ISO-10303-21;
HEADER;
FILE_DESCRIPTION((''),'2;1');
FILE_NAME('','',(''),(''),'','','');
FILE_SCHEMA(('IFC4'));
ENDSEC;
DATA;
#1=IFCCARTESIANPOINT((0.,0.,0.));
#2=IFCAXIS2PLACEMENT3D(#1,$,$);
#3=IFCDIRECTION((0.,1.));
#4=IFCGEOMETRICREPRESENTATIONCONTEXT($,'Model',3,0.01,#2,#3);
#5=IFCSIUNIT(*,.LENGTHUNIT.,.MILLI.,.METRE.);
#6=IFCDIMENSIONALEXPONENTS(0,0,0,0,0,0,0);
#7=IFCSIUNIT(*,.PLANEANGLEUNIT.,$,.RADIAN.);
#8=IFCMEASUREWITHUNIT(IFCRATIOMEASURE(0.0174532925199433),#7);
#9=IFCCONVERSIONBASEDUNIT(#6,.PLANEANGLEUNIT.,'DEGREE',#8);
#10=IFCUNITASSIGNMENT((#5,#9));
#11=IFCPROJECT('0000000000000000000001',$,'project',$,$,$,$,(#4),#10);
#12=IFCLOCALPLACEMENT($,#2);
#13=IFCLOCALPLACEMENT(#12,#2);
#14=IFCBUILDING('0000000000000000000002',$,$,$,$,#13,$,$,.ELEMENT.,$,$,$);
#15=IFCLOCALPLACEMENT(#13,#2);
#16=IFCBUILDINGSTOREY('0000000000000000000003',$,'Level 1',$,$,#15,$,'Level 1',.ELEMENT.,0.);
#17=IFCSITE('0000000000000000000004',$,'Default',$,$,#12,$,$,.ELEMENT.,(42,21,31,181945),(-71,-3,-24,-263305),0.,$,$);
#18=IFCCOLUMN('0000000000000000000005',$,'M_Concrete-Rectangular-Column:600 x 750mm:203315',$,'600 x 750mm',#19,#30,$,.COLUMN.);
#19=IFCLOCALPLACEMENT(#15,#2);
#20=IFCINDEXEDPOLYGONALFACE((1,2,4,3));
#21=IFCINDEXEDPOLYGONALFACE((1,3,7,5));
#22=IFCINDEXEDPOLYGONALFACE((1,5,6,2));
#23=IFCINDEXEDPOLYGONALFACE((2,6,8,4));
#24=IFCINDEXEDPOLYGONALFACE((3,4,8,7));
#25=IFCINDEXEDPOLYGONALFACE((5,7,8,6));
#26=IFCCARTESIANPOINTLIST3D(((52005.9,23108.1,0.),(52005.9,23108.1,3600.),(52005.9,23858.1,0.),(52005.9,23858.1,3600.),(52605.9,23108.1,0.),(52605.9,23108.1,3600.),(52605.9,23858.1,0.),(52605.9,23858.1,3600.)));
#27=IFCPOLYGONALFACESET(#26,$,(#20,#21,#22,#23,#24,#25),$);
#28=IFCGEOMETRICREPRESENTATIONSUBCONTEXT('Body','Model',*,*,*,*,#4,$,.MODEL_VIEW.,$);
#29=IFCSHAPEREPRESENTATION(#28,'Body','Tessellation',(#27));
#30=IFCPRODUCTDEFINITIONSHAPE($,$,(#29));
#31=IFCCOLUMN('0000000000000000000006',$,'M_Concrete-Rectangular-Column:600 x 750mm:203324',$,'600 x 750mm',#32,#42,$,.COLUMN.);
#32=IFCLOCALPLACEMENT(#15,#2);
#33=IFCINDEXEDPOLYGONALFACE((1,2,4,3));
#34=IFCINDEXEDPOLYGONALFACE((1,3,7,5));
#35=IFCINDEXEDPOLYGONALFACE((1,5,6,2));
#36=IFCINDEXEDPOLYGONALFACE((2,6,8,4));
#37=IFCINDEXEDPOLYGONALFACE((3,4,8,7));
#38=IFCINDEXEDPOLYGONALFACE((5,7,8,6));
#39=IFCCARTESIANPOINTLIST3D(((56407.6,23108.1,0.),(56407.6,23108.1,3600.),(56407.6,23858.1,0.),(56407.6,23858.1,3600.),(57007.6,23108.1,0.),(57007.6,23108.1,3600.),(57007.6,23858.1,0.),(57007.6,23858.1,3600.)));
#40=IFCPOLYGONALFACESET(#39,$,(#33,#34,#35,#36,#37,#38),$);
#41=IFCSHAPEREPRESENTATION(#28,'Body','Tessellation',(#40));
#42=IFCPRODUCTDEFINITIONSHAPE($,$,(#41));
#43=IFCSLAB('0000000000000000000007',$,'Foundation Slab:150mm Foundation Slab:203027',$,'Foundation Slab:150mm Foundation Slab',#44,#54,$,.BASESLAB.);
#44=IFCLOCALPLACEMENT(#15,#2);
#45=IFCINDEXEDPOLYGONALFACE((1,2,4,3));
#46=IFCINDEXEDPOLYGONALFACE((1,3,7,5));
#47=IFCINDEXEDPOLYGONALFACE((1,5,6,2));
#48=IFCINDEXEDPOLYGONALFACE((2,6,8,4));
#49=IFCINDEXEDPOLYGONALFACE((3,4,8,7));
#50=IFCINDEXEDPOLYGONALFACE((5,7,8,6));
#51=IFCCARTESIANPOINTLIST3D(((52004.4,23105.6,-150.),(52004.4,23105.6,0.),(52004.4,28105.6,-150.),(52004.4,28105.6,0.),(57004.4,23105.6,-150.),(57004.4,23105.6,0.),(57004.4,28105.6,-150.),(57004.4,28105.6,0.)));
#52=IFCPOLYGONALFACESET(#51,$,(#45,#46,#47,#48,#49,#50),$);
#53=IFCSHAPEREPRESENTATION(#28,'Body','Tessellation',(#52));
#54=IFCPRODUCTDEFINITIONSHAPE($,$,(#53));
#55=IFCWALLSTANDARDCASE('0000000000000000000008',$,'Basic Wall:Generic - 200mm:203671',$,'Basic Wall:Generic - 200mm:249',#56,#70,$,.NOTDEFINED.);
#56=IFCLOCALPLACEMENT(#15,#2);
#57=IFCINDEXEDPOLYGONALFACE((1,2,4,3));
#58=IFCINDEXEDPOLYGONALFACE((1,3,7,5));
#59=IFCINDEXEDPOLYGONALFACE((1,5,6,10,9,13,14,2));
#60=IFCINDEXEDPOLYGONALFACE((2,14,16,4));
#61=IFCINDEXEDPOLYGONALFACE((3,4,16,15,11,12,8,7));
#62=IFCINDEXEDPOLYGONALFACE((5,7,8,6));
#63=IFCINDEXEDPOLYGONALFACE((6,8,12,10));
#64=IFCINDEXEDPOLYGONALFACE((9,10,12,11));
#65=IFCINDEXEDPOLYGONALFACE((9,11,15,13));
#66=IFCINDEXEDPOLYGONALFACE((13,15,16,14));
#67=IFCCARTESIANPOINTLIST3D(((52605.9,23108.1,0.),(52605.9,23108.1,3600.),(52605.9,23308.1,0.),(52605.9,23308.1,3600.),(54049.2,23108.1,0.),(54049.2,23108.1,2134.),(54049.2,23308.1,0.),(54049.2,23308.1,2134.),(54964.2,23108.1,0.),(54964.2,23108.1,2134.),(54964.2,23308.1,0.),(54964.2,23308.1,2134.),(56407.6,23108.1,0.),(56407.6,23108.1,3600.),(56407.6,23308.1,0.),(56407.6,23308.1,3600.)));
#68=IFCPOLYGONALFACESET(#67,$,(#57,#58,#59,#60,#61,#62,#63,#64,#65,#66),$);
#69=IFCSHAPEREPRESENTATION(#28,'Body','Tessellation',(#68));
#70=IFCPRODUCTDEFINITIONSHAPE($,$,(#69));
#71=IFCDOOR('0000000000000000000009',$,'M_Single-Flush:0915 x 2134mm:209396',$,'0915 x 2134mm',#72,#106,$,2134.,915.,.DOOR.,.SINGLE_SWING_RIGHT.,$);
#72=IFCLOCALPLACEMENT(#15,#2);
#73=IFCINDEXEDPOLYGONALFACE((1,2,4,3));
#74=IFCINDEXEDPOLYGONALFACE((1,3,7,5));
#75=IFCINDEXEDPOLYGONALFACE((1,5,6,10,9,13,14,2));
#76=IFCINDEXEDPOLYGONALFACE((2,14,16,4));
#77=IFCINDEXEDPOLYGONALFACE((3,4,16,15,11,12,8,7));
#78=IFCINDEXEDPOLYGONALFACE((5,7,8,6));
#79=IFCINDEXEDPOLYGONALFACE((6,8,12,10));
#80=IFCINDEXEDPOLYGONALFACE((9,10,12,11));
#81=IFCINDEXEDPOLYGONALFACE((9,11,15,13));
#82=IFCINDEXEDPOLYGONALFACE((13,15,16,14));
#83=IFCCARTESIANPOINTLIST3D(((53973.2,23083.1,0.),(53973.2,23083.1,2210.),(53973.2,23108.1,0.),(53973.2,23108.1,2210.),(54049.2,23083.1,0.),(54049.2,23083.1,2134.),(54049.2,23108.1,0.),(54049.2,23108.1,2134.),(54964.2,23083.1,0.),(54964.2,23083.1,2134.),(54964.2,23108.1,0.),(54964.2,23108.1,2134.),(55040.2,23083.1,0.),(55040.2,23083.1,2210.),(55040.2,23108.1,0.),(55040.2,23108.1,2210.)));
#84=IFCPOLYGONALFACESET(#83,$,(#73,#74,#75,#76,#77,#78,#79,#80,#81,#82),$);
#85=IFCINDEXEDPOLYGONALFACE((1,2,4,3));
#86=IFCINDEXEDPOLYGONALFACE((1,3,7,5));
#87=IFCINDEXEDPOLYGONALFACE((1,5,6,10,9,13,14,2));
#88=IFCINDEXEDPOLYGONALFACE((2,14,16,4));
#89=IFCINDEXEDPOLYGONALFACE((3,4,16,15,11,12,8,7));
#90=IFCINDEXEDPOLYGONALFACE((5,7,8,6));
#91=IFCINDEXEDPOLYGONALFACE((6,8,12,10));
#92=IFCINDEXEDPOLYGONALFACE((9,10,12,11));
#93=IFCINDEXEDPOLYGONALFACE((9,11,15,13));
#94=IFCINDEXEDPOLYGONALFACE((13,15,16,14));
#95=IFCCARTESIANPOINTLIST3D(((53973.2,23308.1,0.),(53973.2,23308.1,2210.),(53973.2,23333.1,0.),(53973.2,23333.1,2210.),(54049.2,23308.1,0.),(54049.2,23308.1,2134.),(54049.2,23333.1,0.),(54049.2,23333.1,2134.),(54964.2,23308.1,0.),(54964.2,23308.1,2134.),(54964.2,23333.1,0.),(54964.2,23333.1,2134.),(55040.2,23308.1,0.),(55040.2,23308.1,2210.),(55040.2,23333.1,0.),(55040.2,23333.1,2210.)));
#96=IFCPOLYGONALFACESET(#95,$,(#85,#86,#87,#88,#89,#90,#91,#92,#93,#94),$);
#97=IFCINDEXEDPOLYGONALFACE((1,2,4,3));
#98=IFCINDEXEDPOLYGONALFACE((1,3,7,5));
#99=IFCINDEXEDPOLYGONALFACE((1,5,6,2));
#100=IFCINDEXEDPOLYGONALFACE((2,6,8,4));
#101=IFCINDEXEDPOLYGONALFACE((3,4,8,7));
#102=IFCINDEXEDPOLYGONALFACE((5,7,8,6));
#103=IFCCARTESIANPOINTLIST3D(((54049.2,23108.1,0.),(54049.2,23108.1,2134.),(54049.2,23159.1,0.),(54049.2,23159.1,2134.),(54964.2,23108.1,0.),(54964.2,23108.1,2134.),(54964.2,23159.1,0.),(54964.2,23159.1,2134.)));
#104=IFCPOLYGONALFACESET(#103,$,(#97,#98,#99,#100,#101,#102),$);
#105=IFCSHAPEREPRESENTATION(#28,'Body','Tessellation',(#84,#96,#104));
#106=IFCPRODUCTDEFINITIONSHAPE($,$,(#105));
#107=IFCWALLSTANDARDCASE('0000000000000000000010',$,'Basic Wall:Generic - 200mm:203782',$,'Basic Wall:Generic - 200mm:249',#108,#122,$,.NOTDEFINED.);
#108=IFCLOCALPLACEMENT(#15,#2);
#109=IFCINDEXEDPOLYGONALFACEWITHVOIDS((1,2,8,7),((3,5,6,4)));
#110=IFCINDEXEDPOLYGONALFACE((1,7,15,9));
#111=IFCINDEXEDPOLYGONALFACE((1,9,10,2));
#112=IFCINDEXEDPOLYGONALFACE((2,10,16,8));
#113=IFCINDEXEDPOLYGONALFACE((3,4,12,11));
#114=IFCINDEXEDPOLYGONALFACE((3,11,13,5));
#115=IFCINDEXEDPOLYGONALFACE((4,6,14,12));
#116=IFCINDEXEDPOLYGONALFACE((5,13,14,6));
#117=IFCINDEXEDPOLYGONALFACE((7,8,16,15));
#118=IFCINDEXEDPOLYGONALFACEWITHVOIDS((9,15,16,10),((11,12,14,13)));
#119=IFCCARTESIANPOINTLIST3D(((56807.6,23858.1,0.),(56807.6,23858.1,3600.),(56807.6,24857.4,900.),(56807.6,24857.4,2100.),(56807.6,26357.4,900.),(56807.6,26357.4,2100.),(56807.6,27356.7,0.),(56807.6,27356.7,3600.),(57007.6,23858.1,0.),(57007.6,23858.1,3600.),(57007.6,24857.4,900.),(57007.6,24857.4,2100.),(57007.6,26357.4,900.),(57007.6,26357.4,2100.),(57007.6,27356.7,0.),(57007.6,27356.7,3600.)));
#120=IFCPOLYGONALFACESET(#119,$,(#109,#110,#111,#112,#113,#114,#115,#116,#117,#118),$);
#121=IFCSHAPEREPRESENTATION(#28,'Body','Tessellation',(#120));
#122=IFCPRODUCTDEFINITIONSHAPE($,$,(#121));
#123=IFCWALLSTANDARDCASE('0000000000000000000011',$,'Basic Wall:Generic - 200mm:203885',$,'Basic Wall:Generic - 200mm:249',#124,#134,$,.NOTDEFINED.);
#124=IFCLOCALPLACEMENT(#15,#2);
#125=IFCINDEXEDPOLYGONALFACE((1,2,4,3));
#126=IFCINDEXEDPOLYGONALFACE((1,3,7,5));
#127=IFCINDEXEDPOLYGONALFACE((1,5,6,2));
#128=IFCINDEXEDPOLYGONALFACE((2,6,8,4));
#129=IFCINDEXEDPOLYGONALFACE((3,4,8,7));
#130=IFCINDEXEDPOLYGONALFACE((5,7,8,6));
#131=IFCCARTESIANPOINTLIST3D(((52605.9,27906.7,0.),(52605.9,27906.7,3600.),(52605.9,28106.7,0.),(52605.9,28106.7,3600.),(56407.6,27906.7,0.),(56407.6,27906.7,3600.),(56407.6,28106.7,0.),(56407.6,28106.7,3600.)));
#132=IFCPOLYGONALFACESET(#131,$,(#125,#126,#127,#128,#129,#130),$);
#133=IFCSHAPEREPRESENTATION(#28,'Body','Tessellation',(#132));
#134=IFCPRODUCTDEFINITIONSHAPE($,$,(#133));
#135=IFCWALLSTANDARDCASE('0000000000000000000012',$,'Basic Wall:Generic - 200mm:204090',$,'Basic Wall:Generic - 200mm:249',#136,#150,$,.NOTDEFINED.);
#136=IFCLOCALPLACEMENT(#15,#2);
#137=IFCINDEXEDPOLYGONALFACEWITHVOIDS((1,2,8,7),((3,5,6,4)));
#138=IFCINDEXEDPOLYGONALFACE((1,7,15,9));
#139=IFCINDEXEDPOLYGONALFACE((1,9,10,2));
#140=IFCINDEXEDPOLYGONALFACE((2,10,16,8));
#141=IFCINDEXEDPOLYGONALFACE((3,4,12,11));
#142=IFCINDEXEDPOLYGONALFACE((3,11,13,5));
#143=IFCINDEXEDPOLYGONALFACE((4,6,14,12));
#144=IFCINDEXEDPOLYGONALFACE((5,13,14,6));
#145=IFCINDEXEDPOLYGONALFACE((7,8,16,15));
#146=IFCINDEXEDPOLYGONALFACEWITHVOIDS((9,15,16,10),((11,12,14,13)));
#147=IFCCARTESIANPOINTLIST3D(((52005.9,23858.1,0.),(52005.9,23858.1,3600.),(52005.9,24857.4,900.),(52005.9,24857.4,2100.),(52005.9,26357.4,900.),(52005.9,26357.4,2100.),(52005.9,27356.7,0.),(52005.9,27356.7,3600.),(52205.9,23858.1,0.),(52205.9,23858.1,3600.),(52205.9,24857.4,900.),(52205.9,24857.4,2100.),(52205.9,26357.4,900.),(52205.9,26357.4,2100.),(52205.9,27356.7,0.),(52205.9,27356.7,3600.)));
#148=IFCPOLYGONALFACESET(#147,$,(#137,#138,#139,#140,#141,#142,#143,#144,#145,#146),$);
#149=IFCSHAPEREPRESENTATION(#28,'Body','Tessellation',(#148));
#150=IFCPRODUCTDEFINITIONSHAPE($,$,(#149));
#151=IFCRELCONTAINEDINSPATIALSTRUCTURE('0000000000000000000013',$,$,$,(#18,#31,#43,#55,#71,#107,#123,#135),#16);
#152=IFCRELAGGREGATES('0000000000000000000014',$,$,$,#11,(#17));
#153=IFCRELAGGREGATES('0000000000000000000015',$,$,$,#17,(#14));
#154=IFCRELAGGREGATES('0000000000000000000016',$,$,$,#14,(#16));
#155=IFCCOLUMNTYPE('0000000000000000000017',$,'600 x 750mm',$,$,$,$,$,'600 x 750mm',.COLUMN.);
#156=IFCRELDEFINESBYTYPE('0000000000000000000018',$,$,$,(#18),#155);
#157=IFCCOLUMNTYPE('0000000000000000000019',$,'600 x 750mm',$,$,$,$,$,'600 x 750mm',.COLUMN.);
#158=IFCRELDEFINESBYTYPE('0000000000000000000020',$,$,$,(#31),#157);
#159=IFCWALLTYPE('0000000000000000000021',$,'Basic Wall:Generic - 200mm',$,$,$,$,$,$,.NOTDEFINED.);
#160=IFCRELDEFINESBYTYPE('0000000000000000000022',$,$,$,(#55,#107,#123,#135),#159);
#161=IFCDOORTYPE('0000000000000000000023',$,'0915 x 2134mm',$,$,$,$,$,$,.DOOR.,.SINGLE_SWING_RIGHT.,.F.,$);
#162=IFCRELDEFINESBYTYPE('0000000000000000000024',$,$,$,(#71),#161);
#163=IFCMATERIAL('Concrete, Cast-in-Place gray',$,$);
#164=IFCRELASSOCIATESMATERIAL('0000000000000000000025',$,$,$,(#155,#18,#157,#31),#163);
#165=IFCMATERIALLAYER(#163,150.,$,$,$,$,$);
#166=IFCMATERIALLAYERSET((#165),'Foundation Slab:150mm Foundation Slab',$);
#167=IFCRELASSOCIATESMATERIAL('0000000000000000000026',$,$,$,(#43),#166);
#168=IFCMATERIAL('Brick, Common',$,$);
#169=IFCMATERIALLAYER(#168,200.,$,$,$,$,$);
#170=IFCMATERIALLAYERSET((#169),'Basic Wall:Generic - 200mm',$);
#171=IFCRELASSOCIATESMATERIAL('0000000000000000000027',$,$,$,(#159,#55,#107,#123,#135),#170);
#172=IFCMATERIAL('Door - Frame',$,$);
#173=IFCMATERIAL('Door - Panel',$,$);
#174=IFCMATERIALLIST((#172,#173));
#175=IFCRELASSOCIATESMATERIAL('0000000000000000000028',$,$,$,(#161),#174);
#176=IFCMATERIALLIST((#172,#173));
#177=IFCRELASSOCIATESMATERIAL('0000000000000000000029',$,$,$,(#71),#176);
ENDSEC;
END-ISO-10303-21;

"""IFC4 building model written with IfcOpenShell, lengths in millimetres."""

from ifc_helpers import new_model, entity, si_unit, converted_unit, direction, frame, frame_2d, origin, origin_2d_with_axis, place, context, subcontext, project, spatial, polyline, rectangle, outline, extrude, source, transform, mapped, material, material_list, layer, layer_set, layer_usage, type_object, type_shapes, element, fill, save


model = new_model("IFC4")

# Units and contexts
model_context = context("Model", 3, precision=0.01, world=origin(), true_north=direction((0.0, 1.0)))
body_context = subcontext(model_context, "Body", "Model", "MODEL_VIEW")
ifc_project = project(units=[si_unit("LENGTHUNIT", "METRE", prefix="MILLI"), converted_unit("PLANEANGLEUNIT", "DEGREE", entity("IfcRatioMeasure", 0.0174532925199433), si_unit("PLANEANGLEUNIT", "RADIAN"), dimensions=[0, 0, 0, 0, 0, 0, 0])], contexts=[model_context])

# Site, building, storey
site_placement = place(None, origin())
site = spatial("IfcSite", under=ifc_project, at=site_placement, Name="Default", CompositionType="ELEMENT", RefLatitude=(42, 21, 31, 181945), RefLongitude=(-71, -3, -24, -263305), RefElevation=0.0)
building_placement = place(site_placement, origin())
building = spatial("IfcBuilding", under=site, at=building_placement, CompositionType="ELEMENT")
storey_placement = place(building_placement, origin())
storey = spatial("IfcBuildingStorey", under=building, at=storey_placement, Name="Level 1", LongName="Level 1", CompositionType="ELEMENT", Elevation=0.0)

# Columns
ifc_material_1 = material(Name="Concrete, Cast-in-Place gray")
column_type_1 = type_object("IfcColumnType", Name="600 x 750mm", ElementType="600 x 750mm", PredefinedType="COLUMN", material=ifc_material_1)
shared_shape_1 = source(origin(), body_context, "Body", "SweptSolid", [
    extrude(rectangle(XDim=750.0, YDim=600.0, at=origin_2d_with_axis()), frame((52305.9, 23483.1, 0.0), z_axis=(0.0, 0.0, 1.0), x_axis=(0.0, -1.0, 0.0)), (0.0, 0.0, 1.0), 3600.0),
])
type_shapes(column_type_1, [shared_shape_1])
column_1_placement = place(storey_placement, origin())
element("IfcColumn", 1, at=column_1_placement, inside=storey, type_object=column_type_1, material=ifc_material_1, Name="M_Concrete-Rectangular-Column:600 x 750mm:203315", ObjectType="600 x 750mm", PredefinedType="COLUMN", context=body_context, shape_type="MappedRepresentation", body=[
    mapped(shared_shape_1, transform((0.0, 0.0, 0.0), scale=1.0)),
])
column_type_2 = type_object("IfcColumnType", Name="600 x 750mm", ElementType="600 x 750mm", PredefinedType="COLUMN", material=ifc_material_1)
shared_shape_2 = source(origin(), body_context, "Body", "SweptSolid", [
    extrude(rectangle(XDim=750.0, YDim=600.0, at=origin_2d_with_axis()), frame((56707.6, 23483.1, 0.0), z_axis=(0.0, 0.0, 1.0), x_axis=(0.0, -1.0, 0.0)), (0.0, 0.0, 1.0), 3600.0),
])
type_shapes(column_type_2, [shared_shape_2])
column_2_placement = place(storey_placement, origin())
element("IfcColumn", 2, at=column_2_placement, inside=storey, type_object=column_type_2, material=ifc_material_1, Name="M_Concrete-Rectangular-Column:600 x 750mm:203324", ObjectType="600 x 750mm", PredefinedType="COLUMN", context=body_context, shape_type="MappedRepresentation", body=[
    mapped(shared_shape_2, transform((0.0, 0.0, 0.0), scale=1.0)),
])

# Slab
ifc_layer_1 = layer(ifc_material_1, 150.0)
ifc_layer_set_1 = layer_set([ifc_layer_1], Name="Foundation Slab:150mm Foundation Slab")
ifc_layer_usage_1 = layer_usage(ifc_layer_set_1, "AXIS3", "POSITIVE", 0.0)
slab_placement = place(storey_placement, origin())
element("IfcSlab", 3, at=slab_placement, inside=storey, material=ifc_layer_usage_1, Name="Foundation Slab:150mm Foundation Slab:203027", ObjectType="Foundation Slab:150mm Foundation Slab", PredefinedType="BASESLAB", context=body_context, shape_type="SweptSolid", body=[
    extrude(rectangle(XDim=5000.0, YDim=5000.0, at=frame_2d((0.0, 0.0), x_axis=(1.0, 0.0))), frame((54504.4, 25605.6, 0.0), z_axis=(0.0, 0.0, -1.0), x_axis=(0.0, 1.0, 0.0)), (0.0, 0.0, 1.0), 150.0),
])

# Wall, opening, door
ifc_material_2 = material(Name="Brick, Common")
ifc_layer_2 = layer(ifc_material_2, 200.0)
ifc_layer_set_2 = layer_set([ifc_layer_2], Name="Basic Wall:Generic - 200mm")
ifc_layer_usage_2 = layer_usage(ifc_layer_set_2, "AXIS2", "POSITIVE", -100.0)
wall_type = type_object("IfcWallType", Name="Basic Wall:Generic - 200mm", PredefinedType="NOTDEFINED", material=ifc_layer_set_2)
wall_1_placement = place(storey_placement, frame((52605.9, 23208.1, 0.0)))
wall_1 = element("IfcWallStandardCase", 4, at=wall_1_placement, inside=storey, type_object=wall_type, material=ifc_layer_usage_2, Name="Basic Wall:Generic - 200mm:203671", ObjectType="Basic Wall:Generic - 200mm:249", PredefinedType="NOTDEFINED", context=body_context, shape_type="SweptSolid", body=[
    extrude(rectangle(XDim=3801.7, YDim=200.0, at=frame_2d((1900.8, 0.0), x_axis=(-1.0, 0.0))), origin(), (0.0, 0.0, 1.0), 3600.0),
])
opening_1_placement = place(wall_1_placement, frame((2358.3, 100.0, 0.0)))
opening_1 = element("IfcOpeningElement", 5, at=opening_1_placement, cuts=wall_1, ObjectType="Opening", PredefinedType="OPENING", context=body_context, shape_type="SweptSolid", body=[
    extrude(rectangle(XDim=915.0, YDim=2134.0, at=frame_2d((1067.0, 457.5), x_axis=(0.0, 1.0))), frame((0.0, 0.0, 0.0), z_axis=(0.0, -1.0, 0.0), x_axis=(0.0, 0.0, 1.0)), (0.0, 0.0, 1.0), 200.0),
])
ifc_material_3 = material(Name="Door - Frame")
ifc_material_4 = material(Name="Door - Panel")
ifc_material_list_1 = material_list([ifc_material_3, ifc_material_4])
ifc_material_list_2 = material_list([ifc_material_3, ifc_material_4])
door_type = type_object("IfcDoorType", Name="0915 x 2134mm", OperationType="SINGLE_SWING_RIGHT", ParameterTakesPrecedence=False, PredefinedType="DOOR", material=ifc_material_list_2)
shared_shape_3 = source(origin(), body_context, "Body", "SweptSolid", [
    extrude(outline(polyline([(-533.5, -1124.0), (533.5, -1124.0), (533.5, 1086.0), (457.5, 1086.0), (457.5, -1048.0), (-457.5, -1048.0), (-457.5, 1086.0), (-533.5, 1086.0), (-533.5, -1124.0)])), frame((457.5, 200.0, 1086.0), z_axis=(0.0, 1.0, 0.0), x_axis=(1.0, 0.0, 0.0)), (0.0, 0.0, 1.0), 25.0),
    extrude(outline(polyline([(-1124.0, -533.5), (1086.0, -533.5), (1086.0, -457.5), (-1048.0, -457.5), (-1048.0, 457.5), (1086.0, 457.5), (1086.0, 533.5), (-1124.0, 533.5), (-1124.0, -533.5)])), frame((457.5, -25.0, 1086.0), z_axis=(0.0, 1.0, 0.0), x_axis=(0.0, 0.0, -1.0)), (0.0, 0.0, 1.0), 25.0),
    extrude(rectangle(XDim=51.0, YDim=915.0, at=frame_2d((0.0, 0.0), x_axis=(1.0, 0.0))), frame((457.5, 174.5, 0.0), z_axis=(0.0, 0.0, 1.0), x_axis=(0.0, 1.0, 0.0)), (0.0, 0.0, 1.0), 2134.0),
])
type_shapes(door_type, [shared_shape_3])
door_placement = place(opening_1_placement, frame((0.0, 0.0, 0.0), z_axis=(0.0, 0.0, 1.0), x_axis=(-1.0, 0.0, 0.0)))
door = element("IfcDoor", 6, at=door_placement, inside=storey, type_object=door_type, material=ifc_material_list_1, Name="M_Single-Flush:0915 x 2134mm:209396", ObjectType="0915 x 2134mm", OperationType="SINGLE_SWING_RIGHT", OverallHeight=2134.0, OverallWidth=915.0, PredefinedType="DOOR", context=body_context, shape_type="MappedRepresentation", body=[
    mapped(shared_shape_3, transform((0.0, 0.0, 0.0), scale=1.0)),
])
fill(opening_1, door)

# Wall, opening
ifc_layer_usage_3 = layer_usage(ifc_layer_set_2, "AXIS2", "POSITIVE", -100.0)
wall_2_placement = place(storey_placement, frame((56907.6, 23858.1, 0.0), z_axis=(0.0, 0.0, 1.0), x_axis=(0.0, 1.0, 0.0)))
wall_2 = element("IfcWallStandardCase", 7, at=wall_2_placement, inside=storey, type_object=wall_type, material=ifc_layer_usage_3, Name="Basic Wall:Generic - 200mm:203782", ObjectType="Basic Wall:Generic - 200mm:249", PredefinedType="NOTDEFINED", context=body_context, shape_type="SweptSolid", body=[
    extrude(rectangle(XDim=3498.6, YDim=200.0, at=frame_2d((1749.3, 0.0), x_axis=(-1.0, 0.0))), origin(), (0.0, 0.0, 1.0), 3600.0),
])
opening_2_placement = place(wall_2_placement, frame((999.3, -100.0, 900.0)))
element("IfcOpeningElement", 8, at=opening_2_placement, cuts=wall_2, ObjectType="Opening", PredefinedType="OPENING", context=body_context, shape_type="SweptSolid", body=[
    extrude(rectangle(XDim=1200.0, YDim=1500.0, at=frame_2d((600.0, 750.0), x_axis=(-1.0, 0.0))), frame((0.0, 0.0, 0.0), z_axis=(0.0, 1.0, 0.0), x_axis=(0.0, 0.0, 1.0)), (0.0, 0.0, 1.0), 200.0),
])

# Wall
ifc_layer_usage_4 = layer_usage(ifc_layer_set_2, "AXIS2", "POSITIVE", -100.0)
wall_3_placement = place(storey_placement, frame((56407.6, 28006.7, 0.0), z_axis=(0.0, 0.0, 1.0), x_axis=(-1.0, 0.0, 0.0)))
element("IfcWallStandardCase", 9, at=wall_3_placement, inside=storey, type_object=wall_type, material=ifc_layer_usage_4, Name="Basic Wall:Generic - 200mm:203885", ObjectType="Basic Wall:Generic - 200mm:249", PredefinedType="NOTDEFINED", context=body_context, shape_type="SweptSolid", body=[
    extrude(rectangle(XDim=3801.7, YDim=200.0, at=frame_2d((1900.8, 0.0), x_axis=(-1.0, 0.0))), origin(), (0.0, 0.0, 1.0), 3600.0),
])

# Wall, opening
ifc_layer_usage_5 = layer_usage(ifc_layer_set_2, "AXIS2", "POSITIVE", -100.0)
wall_4_placement = place(storey_placement, frame((52105.9, 27356.7, 0.0), z_axis=(0.0, 0.0, 1.0), x_axis=(0.0, -1.0, 0.0)))
wall_4 = element("IfcWallStandardCase", 10, at=wall_4_placement, inside=storey, type_object=wall_type, material=ifc_layer_usage_5, Name="Basic Wall:Generic - 200mm:204090", ObjectType="Basic Wall:Generic - 200mm:249", PredefinedType="NOTDEFINED", context=body_context, shape_type="SweptSolid", body=[
    extrude(rectangle(XDim=3498.6, YDim=200.0, at=frame_2d((1749.3, 0.0), x_axis=(-1.0, 0.0))), origin(), (0.0, 0.0, 1.0), 3600.0),
])
opening_3_placement = place(wall_4_placement, frame((999.3, -100.0, 900.0)))
element("IfcOpeningElement", 11, at=opening_3_placement, cuts=wall_4, ObjectType="Opening", PredefinedType="OPENING", context=body_context, shape_type="SweptSolid", body=[
    extrude(rectangle(XDim=1200.0, YDim=1500.0, at=frame_2d((600.0, 750.0), x_axis=(-1.0, 0.0))), frame((0.0, 0.0, 0.0), z_axis=(0.0, 1.0, 0.0), x_axis=(0.0, 0.0, 1.0)), (0.0, 0.0, 1.0), 200.0),
])

save(model, "model.ifc")
